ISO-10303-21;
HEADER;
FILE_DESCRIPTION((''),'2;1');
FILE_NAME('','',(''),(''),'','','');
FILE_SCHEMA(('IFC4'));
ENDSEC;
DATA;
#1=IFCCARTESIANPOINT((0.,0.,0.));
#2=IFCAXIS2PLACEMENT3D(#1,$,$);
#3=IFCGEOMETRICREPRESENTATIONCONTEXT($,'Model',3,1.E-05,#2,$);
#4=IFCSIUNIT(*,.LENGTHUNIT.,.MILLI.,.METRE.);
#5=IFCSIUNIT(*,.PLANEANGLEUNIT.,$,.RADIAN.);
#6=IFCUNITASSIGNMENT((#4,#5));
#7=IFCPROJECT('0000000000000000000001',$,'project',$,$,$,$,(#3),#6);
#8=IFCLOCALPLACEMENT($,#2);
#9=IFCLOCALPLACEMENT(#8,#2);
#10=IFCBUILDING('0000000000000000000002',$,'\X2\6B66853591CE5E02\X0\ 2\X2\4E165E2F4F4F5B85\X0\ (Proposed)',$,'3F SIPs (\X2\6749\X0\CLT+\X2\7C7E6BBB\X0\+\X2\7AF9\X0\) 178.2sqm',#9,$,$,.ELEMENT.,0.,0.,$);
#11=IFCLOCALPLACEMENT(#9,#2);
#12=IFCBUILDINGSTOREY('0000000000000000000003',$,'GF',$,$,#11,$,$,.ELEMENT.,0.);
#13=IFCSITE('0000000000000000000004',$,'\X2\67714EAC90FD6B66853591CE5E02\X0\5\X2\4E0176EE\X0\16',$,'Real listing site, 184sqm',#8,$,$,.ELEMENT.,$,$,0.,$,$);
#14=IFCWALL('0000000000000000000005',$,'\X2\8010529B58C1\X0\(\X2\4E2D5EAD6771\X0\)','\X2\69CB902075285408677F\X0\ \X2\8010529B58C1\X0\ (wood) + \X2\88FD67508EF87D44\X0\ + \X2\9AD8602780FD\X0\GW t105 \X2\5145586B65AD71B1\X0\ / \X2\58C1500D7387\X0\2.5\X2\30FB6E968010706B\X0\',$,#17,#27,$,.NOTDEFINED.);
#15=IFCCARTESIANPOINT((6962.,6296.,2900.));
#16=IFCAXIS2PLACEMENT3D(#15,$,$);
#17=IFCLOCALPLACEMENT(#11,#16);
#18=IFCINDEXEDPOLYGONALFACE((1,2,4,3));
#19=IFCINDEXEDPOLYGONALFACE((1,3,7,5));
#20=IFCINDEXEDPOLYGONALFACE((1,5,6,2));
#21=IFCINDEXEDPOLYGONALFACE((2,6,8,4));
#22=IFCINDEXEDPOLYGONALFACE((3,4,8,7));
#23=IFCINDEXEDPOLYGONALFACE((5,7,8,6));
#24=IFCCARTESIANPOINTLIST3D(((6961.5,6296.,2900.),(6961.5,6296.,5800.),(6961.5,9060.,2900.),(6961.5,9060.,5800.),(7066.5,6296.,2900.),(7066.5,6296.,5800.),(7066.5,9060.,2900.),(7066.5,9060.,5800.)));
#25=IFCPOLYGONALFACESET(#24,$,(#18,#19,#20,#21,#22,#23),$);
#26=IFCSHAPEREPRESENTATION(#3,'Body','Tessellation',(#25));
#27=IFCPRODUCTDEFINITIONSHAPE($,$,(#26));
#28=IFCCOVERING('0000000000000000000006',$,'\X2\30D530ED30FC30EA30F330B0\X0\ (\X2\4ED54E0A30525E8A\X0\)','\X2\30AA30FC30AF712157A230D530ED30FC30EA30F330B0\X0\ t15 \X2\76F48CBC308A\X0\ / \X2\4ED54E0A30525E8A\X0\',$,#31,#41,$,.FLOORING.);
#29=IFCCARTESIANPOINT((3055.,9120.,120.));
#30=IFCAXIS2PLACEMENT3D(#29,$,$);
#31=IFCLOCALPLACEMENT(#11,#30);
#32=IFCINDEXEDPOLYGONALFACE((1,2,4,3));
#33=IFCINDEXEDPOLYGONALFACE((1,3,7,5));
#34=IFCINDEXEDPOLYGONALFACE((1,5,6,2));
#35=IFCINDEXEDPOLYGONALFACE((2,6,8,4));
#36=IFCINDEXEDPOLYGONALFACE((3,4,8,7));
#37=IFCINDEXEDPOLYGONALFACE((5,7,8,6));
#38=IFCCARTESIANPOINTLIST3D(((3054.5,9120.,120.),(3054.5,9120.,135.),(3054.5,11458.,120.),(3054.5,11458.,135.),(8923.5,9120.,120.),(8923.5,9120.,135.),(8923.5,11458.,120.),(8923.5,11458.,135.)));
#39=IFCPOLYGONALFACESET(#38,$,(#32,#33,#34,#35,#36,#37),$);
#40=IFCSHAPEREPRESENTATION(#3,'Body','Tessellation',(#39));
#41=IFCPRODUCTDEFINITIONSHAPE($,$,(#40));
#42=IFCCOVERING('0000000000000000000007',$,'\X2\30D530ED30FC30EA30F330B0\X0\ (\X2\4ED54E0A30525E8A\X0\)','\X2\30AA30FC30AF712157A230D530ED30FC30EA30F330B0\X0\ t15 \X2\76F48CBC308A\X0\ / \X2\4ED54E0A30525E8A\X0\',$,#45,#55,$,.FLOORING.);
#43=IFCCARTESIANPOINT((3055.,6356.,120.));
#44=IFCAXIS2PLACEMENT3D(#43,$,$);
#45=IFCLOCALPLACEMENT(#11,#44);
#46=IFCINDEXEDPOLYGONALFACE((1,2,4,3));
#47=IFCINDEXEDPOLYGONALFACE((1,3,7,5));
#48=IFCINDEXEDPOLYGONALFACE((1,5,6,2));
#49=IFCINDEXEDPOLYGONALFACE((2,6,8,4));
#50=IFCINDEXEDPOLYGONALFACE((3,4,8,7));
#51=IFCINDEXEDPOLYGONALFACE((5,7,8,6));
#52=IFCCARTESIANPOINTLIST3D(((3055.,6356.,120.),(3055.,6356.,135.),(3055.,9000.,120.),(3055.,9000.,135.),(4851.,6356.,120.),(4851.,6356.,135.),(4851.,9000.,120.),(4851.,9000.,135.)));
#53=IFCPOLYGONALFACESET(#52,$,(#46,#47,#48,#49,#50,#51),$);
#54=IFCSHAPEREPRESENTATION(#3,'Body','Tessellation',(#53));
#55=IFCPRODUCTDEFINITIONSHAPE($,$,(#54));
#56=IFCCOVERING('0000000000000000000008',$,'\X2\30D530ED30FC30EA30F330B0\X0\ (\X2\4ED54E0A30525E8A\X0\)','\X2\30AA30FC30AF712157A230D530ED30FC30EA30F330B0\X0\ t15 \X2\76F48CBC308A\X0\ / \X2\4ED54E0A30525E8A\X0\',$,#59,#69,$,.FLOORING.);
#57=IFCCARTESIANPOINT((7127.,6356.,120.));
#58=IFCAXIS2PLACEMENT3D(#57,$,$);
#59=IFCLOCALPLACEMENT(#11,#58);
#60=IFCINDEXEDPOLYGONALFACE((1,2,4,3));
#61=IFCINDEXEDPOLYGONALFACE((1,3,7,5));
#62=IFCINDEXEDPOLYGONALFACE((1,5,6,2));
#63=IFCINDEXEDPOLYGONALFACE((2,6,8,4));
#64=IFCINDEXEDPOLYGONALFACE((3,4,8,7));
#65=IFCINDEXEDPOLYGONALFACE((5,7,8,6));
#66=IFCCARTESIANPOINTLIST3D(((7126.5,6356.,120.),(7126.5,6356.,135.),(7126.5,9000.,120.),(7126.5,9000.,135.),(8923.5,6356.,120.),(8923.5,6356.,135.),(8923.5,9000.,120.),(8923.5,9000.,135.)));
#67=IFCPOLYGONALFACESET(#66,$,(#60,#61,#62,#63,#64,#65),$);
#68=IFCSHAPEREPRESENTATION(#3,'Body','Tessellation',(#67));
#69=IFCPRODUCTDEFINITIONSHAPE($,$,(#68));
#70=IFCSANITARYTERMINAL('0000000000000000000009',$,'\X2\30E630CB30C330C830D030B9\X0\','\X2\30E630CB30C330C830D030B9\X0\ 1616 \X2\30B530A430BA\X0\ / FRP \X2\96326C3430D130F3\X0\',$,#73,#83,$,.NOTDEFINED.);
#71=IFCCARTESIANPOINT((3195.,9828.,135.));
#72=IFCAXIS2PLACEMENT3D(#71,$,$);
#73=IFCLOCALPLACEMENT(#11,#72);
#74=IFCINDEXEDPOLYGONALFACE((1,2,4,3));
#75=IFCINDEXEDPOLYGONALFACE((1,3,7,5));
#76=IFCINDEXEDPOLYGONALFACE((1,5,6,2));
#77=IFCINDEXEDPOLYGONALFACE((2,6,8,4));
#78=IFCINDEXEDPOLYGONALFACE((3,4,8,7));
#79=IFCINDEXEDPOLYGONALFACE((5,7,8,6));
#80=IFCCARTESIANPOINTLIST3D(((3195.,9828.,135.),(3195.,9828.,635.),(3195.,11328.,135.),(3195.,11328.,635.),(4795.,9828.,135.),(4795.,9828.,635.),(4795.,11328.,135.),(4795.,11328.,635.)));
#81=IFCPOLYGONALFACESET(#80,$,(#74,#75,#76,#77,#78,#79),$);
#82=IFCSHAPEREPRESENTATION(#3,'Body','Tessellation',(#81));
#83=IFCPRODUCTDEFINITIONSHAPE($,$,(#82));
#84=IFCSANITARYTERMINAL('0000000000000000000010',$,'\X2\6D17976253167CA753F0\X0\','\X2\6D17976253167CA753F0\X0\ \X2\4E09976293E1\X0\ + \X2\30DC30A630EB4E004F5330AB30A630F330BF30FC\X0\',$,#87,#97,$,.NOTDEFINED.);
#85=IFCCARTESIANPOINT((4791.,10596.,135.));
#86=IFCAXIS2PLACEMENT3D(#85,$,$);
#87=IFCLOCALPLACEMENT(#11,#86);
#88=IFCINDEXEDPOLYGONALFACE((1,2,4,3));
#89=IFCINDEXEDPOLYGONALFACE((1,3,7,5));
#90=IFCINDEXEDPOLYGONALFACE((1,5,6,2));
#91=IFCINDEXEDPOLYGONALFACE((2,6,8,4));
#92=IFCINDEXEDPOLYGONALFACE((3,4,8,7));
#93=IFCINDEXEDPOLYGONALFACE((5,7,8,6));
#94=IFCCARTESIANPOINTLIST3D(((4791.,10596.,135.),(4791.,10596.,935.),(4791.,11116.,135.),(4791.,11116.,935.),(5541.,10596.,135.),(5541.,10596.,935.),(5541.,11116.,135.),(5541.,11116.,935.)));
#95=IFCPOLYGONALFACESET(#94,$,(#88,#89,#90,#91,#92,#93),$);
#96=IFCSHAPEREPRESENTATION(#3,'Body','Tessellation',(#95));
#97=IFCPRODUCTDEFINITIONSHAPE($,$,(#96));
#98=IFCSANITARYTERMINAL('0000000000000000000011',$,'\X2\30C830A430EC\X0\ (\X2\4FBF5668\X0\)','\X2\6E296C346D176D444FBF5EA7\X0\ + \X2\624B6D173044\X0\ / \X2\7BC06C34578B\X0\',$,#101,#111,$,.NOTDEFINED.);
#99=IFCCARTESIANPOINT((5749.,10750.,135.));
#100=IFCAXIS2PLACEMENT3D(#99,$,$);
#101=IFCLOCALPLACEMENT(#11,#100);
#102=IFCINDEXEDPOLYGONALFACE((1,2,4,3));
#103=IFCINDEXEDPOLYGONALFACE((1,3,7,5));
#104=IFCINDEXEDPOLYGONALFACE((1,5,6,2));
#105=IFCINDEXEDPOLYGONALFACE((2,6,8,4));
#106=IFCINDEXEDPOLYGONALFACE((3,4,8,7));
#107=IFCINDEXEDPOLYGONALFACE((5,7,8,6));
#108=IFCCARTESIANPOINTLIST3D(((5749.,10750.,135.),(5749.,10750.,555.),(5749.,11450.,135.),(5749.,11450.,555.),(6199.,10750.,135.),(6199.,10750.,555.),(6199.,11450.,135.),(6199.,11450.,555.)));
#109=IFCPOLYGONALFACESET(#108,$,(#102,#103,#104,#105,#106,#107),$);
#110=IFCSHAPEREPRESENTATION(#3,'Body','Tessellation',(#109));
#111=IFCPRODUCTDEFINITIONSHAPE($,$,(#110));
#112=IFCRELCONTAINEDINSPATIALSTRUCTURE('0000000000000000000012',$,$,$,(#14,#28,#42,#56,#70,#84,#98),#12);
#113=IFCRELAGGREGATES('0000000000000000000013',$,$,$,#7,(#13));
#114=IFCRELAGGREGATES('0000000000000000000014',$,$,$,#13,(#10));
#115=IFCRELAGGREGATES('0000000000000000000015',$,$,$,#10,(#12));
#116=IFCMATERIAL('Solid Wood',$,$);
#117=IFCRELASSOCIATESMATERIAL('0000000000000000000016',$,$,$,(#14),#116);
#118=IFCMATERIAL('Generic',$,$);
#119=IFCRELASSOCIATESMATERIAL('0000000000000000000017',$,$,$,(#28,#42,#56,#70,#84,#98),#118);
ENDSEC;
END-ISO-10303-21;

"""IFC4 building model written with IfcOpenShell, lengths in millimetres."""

from ifc_helpers import new_model, si_unit, frame, frame_2d, origin, place, context, project, spatial, rectangle, extrude, material, element, save


model = new_model("IFC4")

# Units and contexts
model_context = context("Model", 3, precision=1e-05, world=origin())
ifc_project = project(units=[si_unit("LENGTHUNIT", "METRE", prefix="MILLI"), si_unit("PLANEANGLEUNIT", "RADIAN")], contexts=[model_context])

# Site, building, storey
site_placement = place(None, origin())
site = spatial("IfcSite", under=ifc_project, at=site_placement, Name="東京都武蔵野市5丁目16", ObjectType="Real listing site, 184sqm", CompositionType="ELEMENT", RefElevation=0.0)
building_placement = place(site_placement, origin())
building = spatial("IfcBuilding", under=site, at=building_placement, Name="武蔵野市 2世帯住宅 (Proposed)", ObjectType="3F SIPs (杉CLT+籾殻+竹) 178.2sqm", CompositionType="ELEMENT", ElevationOfRefHeight=0.0, ElevationOfTerrain=0.0)
storey_placement = place(building_placement, origin())
storey = spatial("IfcBuildingStorey", under=building, at=storey_placement, Name="GF", CompositionType="ELEMENT", Elevation=0.0)

# Shared definitions
ifc_material_1 = material(Name="Solid Wood")

# Wall
wall_1_placement = place(storey_placement, frame((6962.0, 6296.0, 2900.0)))
element("IfcWall", 1, at=wall_1_placement, inside=storey, material=ifc_material_1, Name="耐力壁(中庭東)", Description="構造用合板 耐力壁 (wood) + 製材軸組 + 高性能GW t105 充填断熱 / 壁倍率2.5・準耐火", PredefinedType="NOTDEFINED", context=model_context, shape_type="SweptSolid", body=[
    extrude(rectangle(XDim=105.0, YDim=2764.0, at=frame_2d((52.0, 1382.0))), frame((6962.0, 6296.0, 2900.0)), (0.0, 0.0, 1.0), 2900.0),
])

# Coverings
ifc_material_2 = material(Name="Generic")
covering_1_placement = place(storey_placement, frame((3055.0, 9120.0, 120.0)))
element("IfcCovering", 2, at=covering_1_placement, inside=storey, material=ifc_material_2, Name="フローリング (仕上げ床)", Description="オーク無垢フローリング t15 直貼り / 仕上げ床", PredefinedType="FLOORING", context=model_context, shape_type="SweptSolid", body=[
    extrude(rectangle(XDim=5869.0, YDim=2338.0, at=frame_2d((2934.0, 1169.0))), frame((3055.0, 9120.0, 120.0)), (0.0, 0.0, 1.0), 15.0),
])
covering_2_placement = place(storey_placement, frame((3055.0, 6356.0, 120.0)))
element("IfcCovering", 3, at=covering_2_placement, inside=storey, material=ifc_material_2, Name="フローリング (仕上げ床)", Description="オーク無垢フローリング t15 直貼り / 仕上げ床", PredefinedType="FLOORING", context=model_context, shape_type="SweptSolid", body=[
    extrude(rectangle(XDim=1796.0, YDim=2644.0, at=frame_2d((898.0, 1322.0))), frame((3055.0, 6356.0, 120.0)), (0.0, 0.0, 1.0), 15.0),
])
covering_3_placement = place(storey_placement, frame((7127.0, 6356.0, 120.0)))
element("IfcCovering", 4, at=covering_3_placement, inside=storey, material=ifc_material_2, Name="フローリング (仕上げ床)", Description="オーク無垢フローリング t15 直貼り / 仕上げ床", PredefinedType="FLOORING", context=model_context, shape_type="SweptSolid", body=[
    extrude(rectangle(XDim=1797.0, YDim=2644.0, at=frame_2d((898.0, 1322.0))), frame((7127.0, 6356.0, 120.0)), (0.0, 0.0, 1.0), 15.0),
])

# Sanitary terminals
sanitary_terminal_1_placement = place(storey_placement, frame((3195.0, 9828.0, 135.0)))
element("IfcSanitaryTerminal", 5, at=sanitary_terminal_1_placement, inside=storey, material=ifc_material_2, Name="ユニットバス", Description="ユニットバス 1616 サイズ / FRP 防水パン", PredefinedType="NOTDEFINED", context=model_context, shape_type="SweptSolid", body=[
    extrude(rectangle(XDim=1600.0, YDim=1500.0, at=frame_2d((800.0, 750.0))), frame((3195.0, 9828.0, 135.0)), (0.0, 0.0, 1.0), 500.0),
])
sanitary_terminal_2_placement = place(storey_placement, frame((4791.0, 10596.0, 135.0)))
element("IfcSanitaryTerminal", 6, at=sanitary_terminal_2_placement, inside=storey, material=ifc_material_2, Name="洗面化粧台", Description="洗面化粧台 三面鏡 + ボウル一体カウンター", PredefinedType="NOTDEFINED", context=model_context, shape_type="SweptSolid", body=[
    extrude(rectangle(XDim=750.0, YDim=520.0, at=frame_2d((375.0, 260.0))), frame((4791.0, 10596.0, 135.0)), (0.0, 0.0, 1.0), 800.0),
])
sanitary_terminal_3_placement = place(storey_placement, frame((5749.0, 10750.0, 135.0)))
element("IfcSanitaryTerminal", 7, at=sanitary_terminal_3_placement, inside=storey, material=ifc_material_2, Name="トイレ (便器)", Description="温水洗浄便座 + 手洗い / 節水型", PredefinedType="NOTDEFINED", context=model_context, shape_type="SweptSolid", body=[
    extrude(rectangle(XDim=450.0, YDim=700.0, at=frame_2d((225.0, 350.0))), frame((5749.0, 10750.0, 135.0)), (0.0, 0.0, 1.0), 420.0),
])

save(model, "model.ifc")
